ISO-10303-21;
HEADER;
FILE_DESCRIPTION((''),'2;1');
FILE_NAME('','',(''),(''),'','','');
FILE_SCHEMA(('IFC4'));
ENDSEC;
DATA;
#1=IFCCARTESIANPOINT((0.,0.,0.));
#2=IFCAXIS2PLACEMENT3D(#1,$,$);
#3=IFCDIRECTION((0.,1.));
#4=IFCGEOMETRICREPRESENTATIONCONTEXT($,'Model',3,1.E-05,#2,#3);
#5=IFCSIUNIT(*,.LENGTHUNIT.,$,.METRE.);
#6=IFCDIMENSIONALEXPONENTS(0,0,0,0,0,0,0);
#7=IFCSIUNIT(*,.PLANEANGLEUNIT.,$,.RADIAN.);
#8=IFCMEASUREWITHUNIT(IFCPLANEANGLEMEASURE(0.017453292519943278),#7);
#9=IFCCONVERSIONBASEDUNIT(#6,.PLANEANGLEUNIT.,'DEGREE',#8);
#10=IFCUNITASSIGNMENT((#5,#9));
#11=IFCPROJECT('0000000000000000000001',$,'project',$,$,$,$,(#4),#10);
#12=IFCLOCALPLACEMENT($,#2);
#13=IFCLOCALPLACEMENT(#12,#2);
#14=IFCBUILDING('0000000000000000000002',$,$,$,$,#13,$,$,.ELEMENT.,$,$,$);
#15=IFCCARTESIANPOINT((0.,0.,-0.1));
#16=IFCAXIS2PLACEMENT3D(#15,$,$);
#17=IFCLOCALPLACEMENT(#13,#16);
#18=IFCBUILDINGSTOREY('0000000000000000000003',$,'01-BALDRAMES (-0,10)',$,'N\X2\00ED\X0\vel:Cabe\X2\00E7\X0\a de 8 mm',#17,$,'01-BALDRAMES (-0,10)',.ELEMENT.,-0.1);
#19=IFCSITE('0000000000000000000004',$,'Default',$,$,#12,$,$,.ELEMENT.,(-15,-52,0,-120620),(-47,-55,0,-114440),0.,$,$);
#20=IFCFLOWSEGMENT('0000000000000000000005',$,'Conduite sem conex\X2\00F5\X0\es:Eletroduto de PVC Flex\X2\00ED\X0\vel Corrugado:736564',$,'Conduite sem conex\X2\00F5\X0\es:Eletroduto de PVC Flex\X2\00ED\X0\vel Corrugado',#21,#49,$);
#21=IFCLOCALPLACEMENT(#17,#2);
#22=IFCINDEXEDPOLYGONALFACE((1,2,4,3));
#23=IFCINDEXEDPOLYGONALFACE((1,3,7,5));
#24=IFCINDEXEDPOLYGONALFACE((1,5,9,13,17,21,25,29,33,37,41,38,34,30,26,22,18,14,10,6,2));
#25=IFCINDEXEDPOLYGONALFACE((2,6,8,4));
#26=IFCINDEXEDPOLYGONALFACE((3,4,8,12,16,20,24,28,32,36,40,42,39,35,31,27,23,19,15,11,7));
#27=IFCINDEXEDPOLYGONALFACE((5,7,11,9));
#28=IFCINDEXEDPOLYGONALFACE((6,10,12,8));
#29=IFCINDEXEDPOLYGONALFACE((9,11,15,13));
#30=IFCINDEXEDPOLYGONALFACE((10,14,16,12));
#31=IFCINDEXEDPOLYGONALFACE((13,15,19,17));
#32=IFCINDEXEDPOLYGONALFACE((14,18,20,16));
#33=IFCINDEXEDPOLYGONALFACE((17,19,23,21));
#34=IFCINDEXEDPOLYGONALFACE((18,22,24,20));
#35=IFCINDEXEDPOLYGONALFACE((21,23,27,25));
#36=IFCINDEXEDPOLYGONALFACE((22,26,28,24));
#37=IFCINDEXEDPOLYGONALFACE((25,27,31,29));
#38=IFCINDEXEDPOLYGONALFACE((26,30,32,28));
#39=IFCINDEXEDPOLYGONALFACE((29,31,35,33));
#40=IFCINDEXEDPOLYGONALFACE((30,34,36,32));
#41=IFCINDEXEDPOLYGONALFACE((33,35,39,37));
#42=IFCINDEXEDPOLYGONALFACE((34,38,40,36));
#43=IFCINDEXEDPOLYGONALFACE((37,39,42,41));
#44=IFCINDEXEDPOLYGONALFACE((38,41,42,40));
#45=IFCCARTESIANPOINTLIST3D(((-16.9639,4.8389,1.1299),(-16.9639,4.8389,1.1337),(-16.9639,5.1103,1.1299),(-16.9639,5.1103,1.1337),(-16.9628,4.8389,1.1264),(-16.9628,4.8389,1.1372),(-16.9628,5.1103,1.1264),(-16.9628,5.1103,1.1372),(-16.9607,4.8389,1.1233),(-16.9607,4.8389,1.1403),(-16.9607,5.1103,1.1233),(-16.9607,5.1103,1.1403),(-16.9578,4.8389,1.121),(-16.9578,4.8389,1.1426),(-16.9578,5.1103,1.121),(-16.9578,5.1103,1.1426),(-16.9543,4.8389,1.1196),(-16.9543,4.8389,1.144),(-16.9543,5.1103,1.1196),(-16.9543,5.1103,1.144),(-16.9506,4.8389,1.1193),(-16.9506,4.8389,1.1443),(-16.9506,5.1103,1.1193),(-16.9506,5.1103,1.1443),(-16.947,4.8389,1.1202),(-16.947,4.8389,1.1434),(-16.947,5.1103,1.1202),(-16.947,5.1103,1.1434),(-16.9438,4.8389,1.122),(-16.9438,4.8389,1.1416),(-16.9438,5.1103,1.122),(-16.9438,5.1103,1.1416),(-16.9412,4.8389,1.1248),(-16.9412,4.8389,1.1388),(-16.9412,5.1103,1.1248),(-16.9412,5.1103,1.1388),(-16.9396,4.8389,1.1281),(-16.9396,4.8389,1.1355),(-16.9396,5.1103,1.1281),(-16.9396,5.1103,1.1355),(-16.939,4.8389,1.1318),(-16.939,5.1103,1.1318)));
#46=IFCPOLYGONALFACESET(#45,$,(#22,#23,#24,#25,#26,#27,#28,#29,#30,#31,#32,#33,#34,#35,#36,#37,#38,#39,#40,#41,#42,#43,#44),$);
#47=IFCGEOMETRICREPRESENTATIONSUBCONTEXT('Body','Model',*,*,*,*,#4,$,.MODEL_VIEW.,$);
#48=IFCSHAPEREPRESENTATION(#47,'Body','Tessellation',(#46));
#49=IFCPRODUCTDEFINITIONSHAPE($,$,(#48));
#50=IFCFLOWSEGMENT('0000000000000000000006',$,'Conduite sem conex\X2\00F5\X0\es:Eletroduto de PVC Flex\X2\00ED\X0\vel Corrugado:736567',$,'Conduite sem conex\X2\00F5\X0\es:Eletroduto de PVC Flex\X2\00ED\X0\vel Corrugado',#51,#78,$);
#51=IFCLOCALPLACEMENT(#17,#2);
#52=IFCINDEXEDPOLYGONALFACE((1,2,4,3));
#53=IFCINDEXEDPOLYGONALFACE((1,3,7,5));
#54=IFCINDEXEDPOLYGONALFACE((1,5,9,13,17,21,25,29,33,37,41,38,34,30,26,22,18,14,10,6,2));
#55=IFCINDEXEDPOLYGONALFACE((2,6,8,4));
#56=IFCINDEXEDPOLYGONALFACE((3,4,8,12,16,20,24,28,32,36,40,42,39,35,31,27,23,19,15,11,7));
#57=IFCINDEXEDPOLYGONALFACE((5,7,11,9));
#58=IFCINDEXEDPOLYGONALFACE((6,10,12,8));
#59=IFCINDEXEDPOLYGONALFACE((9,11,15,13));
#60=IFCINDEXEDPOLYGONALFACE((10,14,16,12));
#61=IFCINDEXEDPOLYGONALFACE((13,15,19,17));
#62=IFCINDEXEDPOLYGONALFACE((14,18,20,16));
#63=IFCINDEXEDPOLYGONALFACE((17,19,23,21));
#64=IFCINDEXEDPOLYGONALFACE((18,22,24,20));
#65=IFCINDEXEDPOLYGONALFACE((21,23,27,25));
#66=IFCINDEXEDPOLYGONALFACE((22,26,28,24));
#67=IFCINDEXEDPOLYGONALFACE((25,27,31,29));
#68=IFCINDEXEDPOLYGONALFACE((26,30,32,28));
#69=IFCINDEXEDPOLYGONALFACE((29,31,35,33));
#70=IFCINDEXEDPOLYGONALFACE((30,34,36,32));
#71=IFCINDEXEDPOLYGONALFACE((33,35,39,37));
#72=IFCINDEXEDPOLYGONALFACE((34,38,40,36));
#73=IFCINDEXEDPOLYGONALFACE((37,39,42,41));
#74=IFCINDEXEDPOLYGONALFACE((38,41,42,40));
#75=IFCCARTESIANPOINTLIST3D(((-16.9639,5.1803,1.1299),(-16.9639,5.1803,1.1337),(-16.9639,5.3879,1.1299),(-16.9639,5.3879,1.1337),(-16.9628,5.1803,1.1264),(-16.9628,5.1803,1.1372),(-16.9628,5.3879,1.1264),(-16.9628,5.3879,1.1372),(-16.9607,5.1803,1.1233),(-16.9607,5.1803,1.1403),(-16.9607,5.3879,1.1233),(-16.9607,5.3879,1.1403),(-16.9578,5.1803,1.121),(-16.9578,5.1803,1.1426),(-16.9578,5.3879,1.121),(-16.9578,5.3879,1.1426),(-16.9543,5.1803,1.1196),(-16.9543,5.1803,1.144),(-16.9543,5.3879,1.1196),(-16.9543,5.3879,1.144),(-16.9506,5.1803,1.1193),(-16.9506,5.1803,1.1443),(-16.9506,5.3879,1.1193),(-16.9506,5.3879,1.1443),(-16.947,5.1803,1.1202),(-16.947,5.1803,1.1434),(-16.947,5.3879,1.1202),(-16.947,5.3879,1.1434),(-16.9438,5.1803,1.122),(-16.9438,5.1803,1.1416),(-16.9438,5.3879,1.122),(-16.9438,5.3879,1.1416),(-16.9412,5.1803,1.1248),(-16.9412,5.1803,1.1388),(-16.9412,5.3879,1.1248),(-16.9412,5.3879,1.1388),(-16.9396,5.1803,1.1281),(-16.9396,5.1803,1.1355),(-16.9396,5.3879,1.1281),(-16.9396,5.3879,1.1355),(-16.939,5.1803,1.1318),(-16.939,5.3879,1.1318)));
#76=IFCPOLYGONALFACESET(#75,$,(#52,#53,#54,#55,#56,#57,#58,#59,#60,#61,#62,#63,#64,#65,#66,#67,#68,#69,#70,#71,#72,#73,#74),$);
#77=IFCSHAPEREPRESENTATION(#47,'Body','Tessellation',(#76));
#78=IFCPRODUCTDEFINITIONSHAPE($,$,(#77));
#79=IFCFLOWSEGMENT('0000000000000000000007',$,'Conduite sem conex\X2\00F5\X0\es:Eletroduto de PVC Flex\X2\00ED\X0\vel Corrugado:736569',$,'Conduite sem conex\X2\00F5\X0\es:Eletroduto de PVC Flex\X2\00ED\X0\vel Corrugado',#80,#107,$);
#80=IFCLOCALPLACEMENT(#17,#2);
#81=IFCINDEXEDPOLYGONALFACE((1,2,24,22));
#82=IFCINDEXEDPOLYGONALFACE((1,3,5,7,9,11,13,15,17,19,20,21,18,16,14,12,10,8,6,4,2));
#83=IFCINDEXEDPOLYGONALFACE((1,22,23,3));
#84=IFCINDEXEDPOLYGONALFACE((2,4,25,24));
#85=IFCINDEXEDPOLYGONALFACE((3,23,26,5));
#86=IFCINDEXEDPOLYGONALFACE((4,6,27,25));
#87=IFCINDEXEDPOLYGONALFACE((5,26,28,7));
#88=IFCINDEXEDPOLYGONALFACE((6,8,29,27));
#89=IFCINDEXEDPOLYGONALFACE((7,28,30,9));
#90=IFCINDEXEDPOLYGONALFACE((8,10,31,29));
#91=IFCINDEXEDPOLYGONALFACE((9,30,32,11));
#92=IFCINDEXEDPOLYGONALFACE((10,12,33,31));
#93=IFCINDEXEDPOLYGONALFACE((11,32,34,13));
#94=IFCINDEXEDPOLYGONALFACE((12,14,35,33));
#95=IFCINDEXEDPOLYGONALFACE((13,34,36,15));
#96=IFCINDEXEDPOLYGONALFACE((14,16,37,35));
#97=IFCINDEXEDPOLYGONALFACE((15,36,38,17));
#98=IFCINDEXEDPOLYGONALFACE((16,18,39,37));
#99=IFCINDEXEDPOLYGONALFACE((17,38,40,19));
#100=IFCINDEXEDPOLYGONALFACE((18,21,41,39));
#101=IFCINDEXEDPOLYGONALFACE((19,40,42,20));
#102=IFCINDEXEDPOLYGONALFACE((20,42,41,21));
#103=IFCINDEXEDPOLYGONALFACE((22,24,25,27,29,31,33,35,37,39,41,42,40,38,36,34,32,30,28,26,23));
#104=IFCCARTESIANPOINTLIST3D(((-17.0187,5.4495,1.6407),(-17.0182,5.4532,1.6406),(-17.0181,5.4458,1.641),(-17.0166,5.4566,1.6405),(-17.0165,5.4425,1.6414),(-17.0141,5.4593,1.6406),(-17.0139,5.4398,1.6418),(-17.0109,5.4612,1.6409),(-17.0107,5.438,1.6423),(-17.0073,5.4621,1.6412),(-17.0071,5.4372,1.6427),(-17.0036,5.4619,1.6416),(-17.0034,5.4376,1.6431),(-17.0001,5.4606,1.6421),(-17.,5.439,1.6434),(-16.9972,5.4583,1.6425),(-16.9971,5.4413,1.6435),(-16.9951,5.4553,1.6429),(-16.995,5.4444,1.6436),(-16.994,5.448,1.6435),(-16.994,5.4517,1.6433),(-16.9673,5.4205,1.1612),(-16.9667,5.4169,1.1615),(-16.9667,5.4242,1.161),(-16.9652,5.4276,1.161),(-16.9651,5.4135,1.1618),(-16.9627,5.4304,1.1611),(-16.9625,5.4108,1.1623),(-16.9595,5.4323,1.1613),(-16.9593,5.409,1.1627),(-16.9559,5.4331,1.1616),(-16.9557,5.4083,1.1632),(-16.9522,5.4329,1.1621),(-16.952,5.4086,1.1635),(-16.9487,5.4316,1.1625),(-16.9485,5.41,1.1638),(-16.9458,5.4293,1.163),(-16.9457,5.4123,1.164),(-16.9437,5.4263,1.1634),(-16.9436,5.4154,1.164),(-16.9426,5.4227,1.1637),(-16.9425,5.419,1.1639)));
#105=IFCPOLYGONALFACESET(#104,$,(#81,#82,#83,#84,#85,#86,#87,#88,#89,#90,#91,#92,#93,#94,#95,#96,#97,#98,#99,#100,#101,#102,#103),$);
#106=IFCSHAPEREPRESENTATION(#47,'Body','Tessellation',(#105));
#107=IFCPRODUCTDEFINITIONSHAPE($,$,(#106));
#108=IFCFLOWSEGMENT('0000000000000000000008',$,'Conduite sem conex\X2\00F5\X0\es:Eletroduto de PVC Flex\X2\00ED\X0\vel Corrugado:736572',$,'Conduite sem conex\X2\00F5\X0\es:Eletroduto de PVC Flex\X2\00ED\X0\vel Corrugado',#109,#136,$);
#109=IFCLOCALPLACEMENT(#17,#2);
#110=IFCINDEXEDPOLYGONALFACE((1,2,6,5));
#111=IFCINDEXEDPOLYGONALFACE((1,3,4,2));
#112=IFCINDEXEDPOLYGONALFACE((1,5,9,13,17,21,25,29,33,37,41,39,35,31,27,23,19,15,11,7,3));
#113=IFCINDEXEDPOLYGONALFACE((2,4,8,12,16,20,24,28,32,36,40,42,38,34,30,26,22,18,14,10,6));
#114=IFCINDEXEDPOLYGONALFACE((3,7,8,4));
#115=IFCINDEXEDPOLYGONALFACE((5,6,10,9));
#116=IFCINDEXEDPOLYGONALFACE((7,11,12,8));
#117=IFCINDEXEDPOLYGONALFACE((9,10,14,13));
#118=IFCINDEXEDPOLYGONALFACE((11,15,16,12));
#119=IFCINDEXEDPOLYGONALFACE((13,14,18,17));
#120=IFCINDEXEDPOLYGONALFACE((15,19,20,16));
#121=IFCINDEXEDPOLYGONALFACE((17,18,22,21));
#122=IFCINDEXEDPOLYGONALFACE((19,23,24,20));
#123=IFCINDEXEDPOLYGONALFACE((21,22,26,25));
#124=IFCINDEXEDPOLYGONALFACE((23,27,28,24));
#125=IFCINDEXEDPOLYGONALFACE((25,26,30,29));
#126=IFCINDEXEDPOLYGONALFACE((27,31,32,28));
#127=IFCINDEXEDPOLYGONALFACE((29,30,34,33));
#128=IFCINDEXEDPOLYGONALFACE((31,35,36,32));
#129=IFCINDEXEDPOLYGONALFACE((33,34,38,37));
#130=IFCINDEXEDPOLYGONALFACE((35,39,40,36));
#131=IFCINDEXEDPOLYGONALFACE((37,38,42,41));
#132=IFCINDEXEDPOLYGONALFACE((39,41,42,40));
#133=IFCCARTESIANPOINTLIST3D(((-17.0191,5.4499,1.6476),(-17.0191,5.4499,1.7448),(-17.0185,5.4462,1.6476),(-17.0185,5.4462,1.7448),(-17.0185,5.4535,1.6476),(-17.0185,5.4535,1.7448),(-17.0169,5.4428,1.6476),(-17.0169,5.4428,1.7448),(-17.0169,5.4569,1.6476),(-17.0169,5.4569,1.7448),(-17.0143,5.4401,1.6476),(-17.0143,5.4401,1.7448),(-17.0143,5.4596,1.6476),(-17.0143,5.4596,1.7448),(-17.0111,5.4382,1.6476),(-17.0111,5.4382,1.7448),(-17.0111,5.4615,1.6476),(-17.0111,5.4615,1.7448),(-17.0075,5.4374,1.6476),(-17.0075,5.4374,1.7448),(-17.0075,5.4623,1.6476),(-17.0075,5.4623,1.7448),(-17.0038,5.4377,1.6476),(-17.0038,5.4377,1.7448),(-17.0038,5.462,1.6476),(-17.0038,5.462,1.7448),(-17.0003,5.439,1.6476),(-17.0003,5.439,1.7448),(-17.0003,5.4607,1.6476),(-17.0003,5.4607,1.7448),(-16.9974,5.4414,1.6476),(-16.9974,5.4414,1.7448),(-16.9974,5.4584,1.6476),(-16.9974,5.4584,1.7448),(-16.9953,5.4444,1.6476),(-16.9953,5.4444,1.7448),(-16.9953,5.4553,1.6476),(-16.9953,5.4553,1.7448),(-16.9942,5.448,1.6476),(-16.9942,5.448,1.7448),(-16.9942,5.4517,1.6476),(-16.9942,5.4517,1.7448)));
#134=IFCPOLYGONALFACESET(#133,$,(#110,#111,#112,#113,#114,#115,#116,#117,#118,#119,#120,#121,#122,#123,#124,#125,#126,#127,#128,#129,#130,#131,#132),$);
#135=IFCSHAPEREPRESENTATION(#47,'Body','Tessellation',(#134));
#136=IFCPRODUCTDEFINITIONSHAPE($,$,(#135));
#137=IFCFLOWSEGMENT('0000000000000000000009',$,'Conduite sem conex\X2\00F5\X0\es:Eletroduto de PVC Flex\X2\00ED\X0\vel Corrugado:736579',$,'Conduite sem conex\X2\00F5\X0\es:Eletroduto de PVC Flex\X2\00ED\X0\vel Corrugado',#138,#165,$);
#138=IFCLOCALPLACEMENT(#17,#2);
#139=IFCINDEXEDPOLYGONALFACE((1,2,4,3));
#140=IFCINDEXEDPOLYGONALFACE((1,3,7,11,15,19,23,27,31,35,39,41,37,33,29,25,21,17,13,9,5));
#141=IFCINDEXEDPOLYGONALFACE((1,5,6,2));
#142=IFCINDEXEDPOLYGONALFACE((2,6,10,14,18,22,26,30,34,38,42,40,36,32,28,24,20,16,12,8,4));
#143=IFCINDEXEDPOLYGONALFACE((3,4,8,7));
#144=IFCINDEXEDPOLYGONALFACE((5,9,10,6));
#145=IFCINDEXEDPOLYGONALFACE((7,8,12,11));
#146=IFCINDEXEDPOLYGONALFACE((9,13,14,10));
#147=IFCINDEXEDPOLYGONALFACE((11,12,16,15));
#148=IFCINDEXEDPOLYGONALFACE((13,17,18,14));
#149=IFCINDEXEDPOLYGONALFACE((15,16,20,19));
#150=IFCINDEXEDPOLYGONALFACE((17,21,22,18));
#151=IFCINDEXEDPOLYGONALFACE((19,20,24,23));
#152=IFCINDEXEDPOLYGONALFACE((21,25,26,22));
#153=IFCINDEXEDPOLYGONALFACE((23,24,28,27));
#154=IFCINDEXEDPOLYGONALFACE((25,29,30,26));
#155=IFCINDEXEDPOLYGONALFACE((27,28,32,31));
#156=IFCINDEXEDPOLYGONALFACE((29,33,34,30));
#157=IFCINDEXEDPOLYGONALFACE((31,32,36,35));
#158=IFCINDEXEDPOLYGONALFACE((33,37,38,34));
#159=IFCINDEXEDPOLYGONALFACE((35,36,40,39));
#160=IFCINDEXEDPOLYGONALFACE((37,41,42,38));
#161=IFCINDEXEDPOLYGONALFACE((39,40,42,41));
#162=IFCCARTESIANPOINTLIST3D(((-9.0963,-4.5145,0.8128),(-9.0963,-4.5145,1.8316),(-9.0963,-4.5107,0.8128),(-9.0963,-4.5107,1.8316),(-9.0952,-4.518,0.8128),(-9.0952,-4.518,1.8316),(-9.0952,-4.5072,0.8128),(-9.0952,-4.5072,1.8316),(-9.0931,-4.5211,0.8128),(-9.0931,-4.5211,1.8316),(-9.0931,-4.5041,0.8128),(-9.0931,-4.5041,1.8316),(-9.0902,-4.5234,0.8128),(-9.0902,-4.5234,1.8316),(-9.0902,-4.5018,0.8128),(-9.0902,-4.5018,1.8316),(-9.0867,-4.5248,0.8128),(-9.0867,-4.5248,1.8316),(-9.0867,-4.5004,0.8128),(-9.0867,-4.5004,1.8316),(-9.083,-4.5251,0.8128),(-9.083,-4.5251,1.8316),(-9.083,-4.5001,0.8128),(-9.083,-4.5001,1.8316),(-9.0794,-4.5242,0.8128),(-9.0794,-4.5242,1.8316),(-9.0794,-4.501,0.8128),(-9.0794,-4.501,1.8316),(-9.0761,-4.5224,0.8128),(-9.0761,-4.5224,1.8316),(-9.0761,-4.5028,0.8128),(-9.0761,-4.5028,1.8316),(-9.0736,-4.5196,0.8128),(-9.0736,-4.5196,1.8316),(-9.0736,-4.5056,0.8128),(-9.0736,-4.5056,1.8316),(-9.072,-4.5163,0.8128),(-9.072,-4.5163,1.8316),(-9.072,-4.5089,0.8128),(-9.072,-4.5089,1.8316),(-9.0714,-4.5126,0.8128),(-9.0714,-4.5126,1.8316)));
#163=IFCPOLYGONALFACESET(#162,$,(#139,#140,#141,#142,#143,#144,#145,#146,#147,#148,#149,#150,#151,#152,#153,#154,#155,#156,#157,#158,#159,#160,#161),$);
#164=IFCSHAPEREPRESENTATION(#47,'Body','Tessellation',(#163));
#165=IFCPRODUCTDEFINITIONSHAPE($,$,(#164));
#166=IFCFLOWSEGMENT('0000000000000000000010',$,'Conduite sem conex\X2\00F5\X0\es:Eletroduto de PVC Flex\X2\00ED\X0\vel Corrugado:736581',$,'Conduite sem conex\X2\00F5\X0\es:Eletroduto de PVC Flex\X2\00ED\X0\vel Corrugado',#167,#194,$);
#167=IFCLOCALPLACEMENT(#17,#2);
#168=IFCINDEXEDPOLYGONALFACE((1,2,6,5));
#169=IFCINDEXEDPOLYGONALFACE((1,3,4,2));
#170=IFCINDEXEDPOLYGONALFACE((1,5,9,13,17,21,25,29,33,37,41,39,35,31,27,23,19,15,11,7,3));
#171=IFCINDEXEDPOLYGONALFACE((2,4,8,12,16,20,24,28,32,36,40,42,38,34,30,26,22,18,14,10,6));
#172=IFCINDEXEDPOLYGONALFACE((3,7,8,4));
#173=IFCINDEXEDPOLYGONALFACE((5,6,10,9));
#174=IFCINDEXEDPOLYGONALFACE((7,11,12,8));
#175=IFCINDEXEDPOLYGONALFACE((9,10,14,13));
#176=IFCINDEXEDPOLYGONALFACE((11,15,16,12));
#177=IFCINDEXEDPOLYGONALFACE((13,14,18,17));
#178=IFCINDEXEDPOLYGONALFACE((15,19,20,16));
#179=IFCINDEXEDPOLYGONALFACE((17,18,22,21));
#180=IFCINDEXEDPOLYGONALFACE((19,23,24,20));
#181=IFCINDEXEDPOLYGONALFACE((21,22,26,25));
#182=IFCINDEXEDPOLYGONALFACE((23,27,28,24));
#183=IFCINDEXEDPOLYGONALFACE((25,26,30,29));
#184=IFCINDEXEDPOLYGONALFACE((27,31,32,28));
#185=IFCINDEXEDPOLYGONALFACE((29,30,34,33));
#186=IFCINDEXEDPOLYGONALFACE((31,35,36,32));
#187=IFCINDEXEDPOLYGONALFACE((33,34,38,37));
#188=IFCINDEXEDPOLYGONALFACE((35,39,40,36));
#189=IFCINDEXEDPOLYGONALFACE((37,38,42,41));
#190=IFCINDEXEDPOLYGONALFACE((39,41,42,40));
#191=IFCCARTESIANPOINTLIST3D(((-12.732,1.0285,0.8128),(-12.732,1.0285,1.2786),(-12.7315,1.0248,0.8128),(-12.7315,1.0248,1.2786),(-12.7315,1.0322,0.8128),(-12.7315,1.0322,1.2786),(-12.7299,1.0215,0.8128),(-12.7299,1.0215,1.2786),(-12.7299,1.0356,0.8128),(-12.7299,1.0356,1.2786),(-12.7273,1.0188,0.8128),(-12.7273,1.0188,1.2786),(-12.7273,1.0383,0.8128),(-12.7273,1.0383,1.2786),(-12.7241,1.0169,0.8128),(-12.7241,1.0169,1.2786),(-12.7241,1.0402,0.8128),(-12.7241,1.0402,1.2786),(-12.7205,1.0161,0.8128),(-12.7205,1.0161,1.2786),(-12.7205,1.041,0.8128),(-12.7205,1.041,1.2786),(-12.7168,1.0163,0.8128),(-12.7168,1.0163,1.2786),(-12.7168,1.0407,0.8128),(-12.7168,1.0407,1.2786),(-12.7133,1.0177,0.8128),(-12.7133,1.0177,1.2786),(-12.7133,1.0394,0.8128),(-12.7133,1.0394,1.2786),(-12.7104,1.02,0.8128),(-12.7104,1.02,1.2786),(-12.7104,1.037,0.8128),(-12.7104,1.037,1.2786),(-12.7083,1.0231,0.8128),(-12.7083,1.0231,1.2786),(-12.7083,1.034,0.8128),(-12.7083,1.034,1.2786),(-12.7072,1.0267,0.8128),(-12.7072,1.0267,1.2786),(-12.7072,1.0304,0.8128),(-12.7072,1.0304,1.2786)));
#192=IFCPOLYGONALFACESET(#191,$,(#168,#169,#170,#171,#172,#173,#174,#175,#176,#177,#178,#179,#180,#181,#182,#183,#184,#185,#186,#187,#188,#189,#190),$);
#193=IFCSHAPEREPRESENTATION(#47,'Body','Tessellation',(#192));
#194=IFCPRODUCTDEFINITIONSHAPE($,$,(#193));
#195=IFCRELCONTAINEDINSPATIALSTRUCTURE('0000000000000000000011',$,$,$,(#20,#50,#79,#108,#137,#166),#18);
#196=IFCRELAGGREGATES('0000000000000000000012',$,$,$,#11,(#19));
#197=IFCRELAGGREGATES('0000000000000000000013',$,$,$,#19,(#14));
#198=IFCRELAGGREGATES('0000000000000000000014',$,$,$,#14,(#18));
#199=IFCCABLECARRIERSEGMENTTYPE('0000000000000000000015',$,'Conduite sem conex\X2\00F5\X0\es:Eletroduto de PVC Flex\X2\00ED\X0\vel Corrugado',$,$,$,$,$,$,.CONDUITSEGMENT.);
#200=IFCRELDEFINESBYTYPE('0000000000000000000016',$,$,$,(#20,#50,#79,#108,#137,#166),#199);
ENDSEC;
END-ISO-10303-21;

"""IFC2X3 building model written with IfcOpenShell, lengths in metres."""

from ifc_helpers import new_model, entity, si_unit, converted_unit, direction, frame, frame_2d, origin, origin_2d_with_axis, place, context, subcontext, project, spatial, circle, extrude, type_object, element, save


model = new_model("IFC2X3")

# Units and contexts
model_context = context("Model", 3, precision=1e-05, world=origin(), true_north=direction((0.0, 1.0)))
body_context = subcontext(model_context, "Body", "Model", "MODEL_VIEW")
ifc_project = project(units=[si_unit("LENGTHUNIT", "METRE"), converted_unit("PLANEANGLEUNIT", "DEGREE", entity("IfcPlaneAngleMeasure", 0.017453292519943278), si_unit("PLANEANGLEUNIT", "RADIAN"), dimensions=[0, 0, 0, 0, 0, 0, 0])], contexts=[model_context])

# Site, building, storey
site_placement = place(None, origin())
site = spatial("IfcSite", under=ifc_project, at=site_placement, Name="Default", CompositionType="ELEMENT", RefLatitude=(-15, -52, 0, -120620), RefLongitude=(-47, -55, 0, -114440), RefElevation=0.0)
building_placement = place(site_placement, origin())
building = spatial("IfcBuilding", under=site, at=building_placement, CompositionType="ELEMENT")
storey_placement = place(building_placement, frame((0.0, 0.0, -0.1)))
storey = spatial("IfcBuildingStorey", under=building, at=storey_placement, Name="01-BALDRAMES (-0,10)", ObjectType="Nível:Cabeça de 8 mm", LongName="01-BALDRAMES (-0,10)", CompositionType="ELEMENT", Elevation=-0.1)

# Flow segments
cable_carrier_segment_type = type_object("IfcCableCarrierSegmentType", Name="Conduite sem conexões:Eletroduto de PVC Flexível Corrugado", PredefinedType="CONDUITSEGMENT")
flow_segment_1_placement = place(storey_placement, origin())
element("IfcFlowSegment", 1, at=flow_segment_1_placement, inside=storey, type_object=cable_carrier_segment_type, Name="Conduite sem conexões:Eletroduto de PVC Flexível Corrugado:736564", ObjectType="Conduite sem conexões:Eletroduto de PVC Flexível Corrugado", context=body_context, shape_type="SweptSolid", body=[
    extrude(circle(Radius=0.0125, at=frame_2d((0.0, 0.0), x_axis=(1.0, 0.0))), frame((-16.9515, 4.8389, 1.1318), z_axis=(0.000009, 1.0, 0.0), x_axis=(1.0, -0.000009, 0.0)), (0.0, 0.0, 1.0), 0.2714),
])
flow_segment_2_placement = place(storey_placement, origin())
element("IfcFlowSegment", 2, at=flow_segment_2_placement, inside=storey, type_object=cable_carrier_segment_type, Name="Conduite sem conexões:Eletroduto de PVC Flexível Corrugado:736567", ObjectType="Conduite sem conexões:Eletroduto de PVC Flexível Corrugado", context=body_context, shape_type="SweptSolid", body=[
    extrude(circle(Radius=0.0125, at=frame_2d((0.0, 0.0), x_axis=(1.0, 0.0))), frame((-16.9515, 5.1803, 1.1318), z_axis=(0.0, 1.0, 0.0), x_axis=(1.0, 0.0, 0.0)), (0.0, 0.0, 1.0), 0.2076),
])
flow_segment_3_placement = place(storey_placement, origin())
element("IfcFlowSegment", 3, at=flow_segment_3_placement, inside=storey, type_object=cable_carrier_segment_type, Name="Conduite sem conexões:Eletroduto de PVC Flexível Corrugado:736569", ObjectType="Conduite sem conexões:Eletroduto de PVC Flexível Corrugado", context=body_context, shape_type="SweptSolid", body=[
    extrude(circle(Radius=0.0125, at=origin_2d_with_axis()), frame((-17.0063, 5.4497, 1.6421), z_axis=(0.106418, -0.05998, -0.992511), x_axis=(0.491006, 0.871156, 0.0)), (0.0, 0.0, 1.0), 0.4832),
])
flow_segment_4_placement = place(storey_placement, origin())
element("IfcFlowSegment", 4, at=flow_segment_4_placement, inside=storey, type_object=cable_carrier_segment_type, Name="Conduite sem conexões:Eletroduto de PVC Flexível Corrugado:736572", ObjectType="Conduite sem conexões:Eletroduto de PVC Flexível Corrugado", context=body_context, shape_type="SweptSolid", body=[
    extrude(circle(Radius=0.0125, at=frame_2d((0.0, 0.0), x_axis=(1.0, 0.0))), frame((-17.0066, 5.4499, 1.6476), z_axis=(0.0, 0.0, 1.0), x_axis=(-1.0, 0.0, 0.0)), (0.0, 0.0, 1.0), 0.0972),
])
flow_segment_5_placement = place(storey_placement, origin())
element("IfcFlowSegment", 5, at=flow_segment_5_placement, inside=storey, type_object=cable_carrier_segment_type, Name="Conduite sem conexões:Eletroduto de PVC Flexível Corrugado:736579", ObjectType="Conduite sem conexões:Eletroduto de PVC Flexível Corrugado", context=body_context, shape_type="SweptSolid", body=[
    extrude(circle(Radius=0.0125, at=frame_2d((0.0, 0.0), x_axis=(1.0, 0.0))), frame((-9.0839, -4.5126, 0.8128)), (0.0, 0.0, 1.0), 1.0187),
])
flow_segment_6_placement = place(storey_placement, origin())
element("IfcFlowSegment", 6, at=flow_segment_6_placement, inside=storey, type_object=cable_carrier_segment_type, Name="Conduite sem conexões:Eletroduto de PVC Flexível Corrugado:736581", ObjectType="Conduite sem conexões:Eletroduto de PVC Flexível Corrugado", context=body_context, shape_type="SweptSolid", body=[
    extrude(circle(Radius=0.0125, at=frame_2d((0.0, 0.0), x_axis=(1.0, 0.0))), frame((-12.7195, 1.0285, 0.8128), z_axis=(0.0, 0.0, 1.0), x_axis=(-1.0, 0.0, 0.0)), (0.0, 0.0, 1.0), 0.4658),
])

save(model, "model.ifc")
